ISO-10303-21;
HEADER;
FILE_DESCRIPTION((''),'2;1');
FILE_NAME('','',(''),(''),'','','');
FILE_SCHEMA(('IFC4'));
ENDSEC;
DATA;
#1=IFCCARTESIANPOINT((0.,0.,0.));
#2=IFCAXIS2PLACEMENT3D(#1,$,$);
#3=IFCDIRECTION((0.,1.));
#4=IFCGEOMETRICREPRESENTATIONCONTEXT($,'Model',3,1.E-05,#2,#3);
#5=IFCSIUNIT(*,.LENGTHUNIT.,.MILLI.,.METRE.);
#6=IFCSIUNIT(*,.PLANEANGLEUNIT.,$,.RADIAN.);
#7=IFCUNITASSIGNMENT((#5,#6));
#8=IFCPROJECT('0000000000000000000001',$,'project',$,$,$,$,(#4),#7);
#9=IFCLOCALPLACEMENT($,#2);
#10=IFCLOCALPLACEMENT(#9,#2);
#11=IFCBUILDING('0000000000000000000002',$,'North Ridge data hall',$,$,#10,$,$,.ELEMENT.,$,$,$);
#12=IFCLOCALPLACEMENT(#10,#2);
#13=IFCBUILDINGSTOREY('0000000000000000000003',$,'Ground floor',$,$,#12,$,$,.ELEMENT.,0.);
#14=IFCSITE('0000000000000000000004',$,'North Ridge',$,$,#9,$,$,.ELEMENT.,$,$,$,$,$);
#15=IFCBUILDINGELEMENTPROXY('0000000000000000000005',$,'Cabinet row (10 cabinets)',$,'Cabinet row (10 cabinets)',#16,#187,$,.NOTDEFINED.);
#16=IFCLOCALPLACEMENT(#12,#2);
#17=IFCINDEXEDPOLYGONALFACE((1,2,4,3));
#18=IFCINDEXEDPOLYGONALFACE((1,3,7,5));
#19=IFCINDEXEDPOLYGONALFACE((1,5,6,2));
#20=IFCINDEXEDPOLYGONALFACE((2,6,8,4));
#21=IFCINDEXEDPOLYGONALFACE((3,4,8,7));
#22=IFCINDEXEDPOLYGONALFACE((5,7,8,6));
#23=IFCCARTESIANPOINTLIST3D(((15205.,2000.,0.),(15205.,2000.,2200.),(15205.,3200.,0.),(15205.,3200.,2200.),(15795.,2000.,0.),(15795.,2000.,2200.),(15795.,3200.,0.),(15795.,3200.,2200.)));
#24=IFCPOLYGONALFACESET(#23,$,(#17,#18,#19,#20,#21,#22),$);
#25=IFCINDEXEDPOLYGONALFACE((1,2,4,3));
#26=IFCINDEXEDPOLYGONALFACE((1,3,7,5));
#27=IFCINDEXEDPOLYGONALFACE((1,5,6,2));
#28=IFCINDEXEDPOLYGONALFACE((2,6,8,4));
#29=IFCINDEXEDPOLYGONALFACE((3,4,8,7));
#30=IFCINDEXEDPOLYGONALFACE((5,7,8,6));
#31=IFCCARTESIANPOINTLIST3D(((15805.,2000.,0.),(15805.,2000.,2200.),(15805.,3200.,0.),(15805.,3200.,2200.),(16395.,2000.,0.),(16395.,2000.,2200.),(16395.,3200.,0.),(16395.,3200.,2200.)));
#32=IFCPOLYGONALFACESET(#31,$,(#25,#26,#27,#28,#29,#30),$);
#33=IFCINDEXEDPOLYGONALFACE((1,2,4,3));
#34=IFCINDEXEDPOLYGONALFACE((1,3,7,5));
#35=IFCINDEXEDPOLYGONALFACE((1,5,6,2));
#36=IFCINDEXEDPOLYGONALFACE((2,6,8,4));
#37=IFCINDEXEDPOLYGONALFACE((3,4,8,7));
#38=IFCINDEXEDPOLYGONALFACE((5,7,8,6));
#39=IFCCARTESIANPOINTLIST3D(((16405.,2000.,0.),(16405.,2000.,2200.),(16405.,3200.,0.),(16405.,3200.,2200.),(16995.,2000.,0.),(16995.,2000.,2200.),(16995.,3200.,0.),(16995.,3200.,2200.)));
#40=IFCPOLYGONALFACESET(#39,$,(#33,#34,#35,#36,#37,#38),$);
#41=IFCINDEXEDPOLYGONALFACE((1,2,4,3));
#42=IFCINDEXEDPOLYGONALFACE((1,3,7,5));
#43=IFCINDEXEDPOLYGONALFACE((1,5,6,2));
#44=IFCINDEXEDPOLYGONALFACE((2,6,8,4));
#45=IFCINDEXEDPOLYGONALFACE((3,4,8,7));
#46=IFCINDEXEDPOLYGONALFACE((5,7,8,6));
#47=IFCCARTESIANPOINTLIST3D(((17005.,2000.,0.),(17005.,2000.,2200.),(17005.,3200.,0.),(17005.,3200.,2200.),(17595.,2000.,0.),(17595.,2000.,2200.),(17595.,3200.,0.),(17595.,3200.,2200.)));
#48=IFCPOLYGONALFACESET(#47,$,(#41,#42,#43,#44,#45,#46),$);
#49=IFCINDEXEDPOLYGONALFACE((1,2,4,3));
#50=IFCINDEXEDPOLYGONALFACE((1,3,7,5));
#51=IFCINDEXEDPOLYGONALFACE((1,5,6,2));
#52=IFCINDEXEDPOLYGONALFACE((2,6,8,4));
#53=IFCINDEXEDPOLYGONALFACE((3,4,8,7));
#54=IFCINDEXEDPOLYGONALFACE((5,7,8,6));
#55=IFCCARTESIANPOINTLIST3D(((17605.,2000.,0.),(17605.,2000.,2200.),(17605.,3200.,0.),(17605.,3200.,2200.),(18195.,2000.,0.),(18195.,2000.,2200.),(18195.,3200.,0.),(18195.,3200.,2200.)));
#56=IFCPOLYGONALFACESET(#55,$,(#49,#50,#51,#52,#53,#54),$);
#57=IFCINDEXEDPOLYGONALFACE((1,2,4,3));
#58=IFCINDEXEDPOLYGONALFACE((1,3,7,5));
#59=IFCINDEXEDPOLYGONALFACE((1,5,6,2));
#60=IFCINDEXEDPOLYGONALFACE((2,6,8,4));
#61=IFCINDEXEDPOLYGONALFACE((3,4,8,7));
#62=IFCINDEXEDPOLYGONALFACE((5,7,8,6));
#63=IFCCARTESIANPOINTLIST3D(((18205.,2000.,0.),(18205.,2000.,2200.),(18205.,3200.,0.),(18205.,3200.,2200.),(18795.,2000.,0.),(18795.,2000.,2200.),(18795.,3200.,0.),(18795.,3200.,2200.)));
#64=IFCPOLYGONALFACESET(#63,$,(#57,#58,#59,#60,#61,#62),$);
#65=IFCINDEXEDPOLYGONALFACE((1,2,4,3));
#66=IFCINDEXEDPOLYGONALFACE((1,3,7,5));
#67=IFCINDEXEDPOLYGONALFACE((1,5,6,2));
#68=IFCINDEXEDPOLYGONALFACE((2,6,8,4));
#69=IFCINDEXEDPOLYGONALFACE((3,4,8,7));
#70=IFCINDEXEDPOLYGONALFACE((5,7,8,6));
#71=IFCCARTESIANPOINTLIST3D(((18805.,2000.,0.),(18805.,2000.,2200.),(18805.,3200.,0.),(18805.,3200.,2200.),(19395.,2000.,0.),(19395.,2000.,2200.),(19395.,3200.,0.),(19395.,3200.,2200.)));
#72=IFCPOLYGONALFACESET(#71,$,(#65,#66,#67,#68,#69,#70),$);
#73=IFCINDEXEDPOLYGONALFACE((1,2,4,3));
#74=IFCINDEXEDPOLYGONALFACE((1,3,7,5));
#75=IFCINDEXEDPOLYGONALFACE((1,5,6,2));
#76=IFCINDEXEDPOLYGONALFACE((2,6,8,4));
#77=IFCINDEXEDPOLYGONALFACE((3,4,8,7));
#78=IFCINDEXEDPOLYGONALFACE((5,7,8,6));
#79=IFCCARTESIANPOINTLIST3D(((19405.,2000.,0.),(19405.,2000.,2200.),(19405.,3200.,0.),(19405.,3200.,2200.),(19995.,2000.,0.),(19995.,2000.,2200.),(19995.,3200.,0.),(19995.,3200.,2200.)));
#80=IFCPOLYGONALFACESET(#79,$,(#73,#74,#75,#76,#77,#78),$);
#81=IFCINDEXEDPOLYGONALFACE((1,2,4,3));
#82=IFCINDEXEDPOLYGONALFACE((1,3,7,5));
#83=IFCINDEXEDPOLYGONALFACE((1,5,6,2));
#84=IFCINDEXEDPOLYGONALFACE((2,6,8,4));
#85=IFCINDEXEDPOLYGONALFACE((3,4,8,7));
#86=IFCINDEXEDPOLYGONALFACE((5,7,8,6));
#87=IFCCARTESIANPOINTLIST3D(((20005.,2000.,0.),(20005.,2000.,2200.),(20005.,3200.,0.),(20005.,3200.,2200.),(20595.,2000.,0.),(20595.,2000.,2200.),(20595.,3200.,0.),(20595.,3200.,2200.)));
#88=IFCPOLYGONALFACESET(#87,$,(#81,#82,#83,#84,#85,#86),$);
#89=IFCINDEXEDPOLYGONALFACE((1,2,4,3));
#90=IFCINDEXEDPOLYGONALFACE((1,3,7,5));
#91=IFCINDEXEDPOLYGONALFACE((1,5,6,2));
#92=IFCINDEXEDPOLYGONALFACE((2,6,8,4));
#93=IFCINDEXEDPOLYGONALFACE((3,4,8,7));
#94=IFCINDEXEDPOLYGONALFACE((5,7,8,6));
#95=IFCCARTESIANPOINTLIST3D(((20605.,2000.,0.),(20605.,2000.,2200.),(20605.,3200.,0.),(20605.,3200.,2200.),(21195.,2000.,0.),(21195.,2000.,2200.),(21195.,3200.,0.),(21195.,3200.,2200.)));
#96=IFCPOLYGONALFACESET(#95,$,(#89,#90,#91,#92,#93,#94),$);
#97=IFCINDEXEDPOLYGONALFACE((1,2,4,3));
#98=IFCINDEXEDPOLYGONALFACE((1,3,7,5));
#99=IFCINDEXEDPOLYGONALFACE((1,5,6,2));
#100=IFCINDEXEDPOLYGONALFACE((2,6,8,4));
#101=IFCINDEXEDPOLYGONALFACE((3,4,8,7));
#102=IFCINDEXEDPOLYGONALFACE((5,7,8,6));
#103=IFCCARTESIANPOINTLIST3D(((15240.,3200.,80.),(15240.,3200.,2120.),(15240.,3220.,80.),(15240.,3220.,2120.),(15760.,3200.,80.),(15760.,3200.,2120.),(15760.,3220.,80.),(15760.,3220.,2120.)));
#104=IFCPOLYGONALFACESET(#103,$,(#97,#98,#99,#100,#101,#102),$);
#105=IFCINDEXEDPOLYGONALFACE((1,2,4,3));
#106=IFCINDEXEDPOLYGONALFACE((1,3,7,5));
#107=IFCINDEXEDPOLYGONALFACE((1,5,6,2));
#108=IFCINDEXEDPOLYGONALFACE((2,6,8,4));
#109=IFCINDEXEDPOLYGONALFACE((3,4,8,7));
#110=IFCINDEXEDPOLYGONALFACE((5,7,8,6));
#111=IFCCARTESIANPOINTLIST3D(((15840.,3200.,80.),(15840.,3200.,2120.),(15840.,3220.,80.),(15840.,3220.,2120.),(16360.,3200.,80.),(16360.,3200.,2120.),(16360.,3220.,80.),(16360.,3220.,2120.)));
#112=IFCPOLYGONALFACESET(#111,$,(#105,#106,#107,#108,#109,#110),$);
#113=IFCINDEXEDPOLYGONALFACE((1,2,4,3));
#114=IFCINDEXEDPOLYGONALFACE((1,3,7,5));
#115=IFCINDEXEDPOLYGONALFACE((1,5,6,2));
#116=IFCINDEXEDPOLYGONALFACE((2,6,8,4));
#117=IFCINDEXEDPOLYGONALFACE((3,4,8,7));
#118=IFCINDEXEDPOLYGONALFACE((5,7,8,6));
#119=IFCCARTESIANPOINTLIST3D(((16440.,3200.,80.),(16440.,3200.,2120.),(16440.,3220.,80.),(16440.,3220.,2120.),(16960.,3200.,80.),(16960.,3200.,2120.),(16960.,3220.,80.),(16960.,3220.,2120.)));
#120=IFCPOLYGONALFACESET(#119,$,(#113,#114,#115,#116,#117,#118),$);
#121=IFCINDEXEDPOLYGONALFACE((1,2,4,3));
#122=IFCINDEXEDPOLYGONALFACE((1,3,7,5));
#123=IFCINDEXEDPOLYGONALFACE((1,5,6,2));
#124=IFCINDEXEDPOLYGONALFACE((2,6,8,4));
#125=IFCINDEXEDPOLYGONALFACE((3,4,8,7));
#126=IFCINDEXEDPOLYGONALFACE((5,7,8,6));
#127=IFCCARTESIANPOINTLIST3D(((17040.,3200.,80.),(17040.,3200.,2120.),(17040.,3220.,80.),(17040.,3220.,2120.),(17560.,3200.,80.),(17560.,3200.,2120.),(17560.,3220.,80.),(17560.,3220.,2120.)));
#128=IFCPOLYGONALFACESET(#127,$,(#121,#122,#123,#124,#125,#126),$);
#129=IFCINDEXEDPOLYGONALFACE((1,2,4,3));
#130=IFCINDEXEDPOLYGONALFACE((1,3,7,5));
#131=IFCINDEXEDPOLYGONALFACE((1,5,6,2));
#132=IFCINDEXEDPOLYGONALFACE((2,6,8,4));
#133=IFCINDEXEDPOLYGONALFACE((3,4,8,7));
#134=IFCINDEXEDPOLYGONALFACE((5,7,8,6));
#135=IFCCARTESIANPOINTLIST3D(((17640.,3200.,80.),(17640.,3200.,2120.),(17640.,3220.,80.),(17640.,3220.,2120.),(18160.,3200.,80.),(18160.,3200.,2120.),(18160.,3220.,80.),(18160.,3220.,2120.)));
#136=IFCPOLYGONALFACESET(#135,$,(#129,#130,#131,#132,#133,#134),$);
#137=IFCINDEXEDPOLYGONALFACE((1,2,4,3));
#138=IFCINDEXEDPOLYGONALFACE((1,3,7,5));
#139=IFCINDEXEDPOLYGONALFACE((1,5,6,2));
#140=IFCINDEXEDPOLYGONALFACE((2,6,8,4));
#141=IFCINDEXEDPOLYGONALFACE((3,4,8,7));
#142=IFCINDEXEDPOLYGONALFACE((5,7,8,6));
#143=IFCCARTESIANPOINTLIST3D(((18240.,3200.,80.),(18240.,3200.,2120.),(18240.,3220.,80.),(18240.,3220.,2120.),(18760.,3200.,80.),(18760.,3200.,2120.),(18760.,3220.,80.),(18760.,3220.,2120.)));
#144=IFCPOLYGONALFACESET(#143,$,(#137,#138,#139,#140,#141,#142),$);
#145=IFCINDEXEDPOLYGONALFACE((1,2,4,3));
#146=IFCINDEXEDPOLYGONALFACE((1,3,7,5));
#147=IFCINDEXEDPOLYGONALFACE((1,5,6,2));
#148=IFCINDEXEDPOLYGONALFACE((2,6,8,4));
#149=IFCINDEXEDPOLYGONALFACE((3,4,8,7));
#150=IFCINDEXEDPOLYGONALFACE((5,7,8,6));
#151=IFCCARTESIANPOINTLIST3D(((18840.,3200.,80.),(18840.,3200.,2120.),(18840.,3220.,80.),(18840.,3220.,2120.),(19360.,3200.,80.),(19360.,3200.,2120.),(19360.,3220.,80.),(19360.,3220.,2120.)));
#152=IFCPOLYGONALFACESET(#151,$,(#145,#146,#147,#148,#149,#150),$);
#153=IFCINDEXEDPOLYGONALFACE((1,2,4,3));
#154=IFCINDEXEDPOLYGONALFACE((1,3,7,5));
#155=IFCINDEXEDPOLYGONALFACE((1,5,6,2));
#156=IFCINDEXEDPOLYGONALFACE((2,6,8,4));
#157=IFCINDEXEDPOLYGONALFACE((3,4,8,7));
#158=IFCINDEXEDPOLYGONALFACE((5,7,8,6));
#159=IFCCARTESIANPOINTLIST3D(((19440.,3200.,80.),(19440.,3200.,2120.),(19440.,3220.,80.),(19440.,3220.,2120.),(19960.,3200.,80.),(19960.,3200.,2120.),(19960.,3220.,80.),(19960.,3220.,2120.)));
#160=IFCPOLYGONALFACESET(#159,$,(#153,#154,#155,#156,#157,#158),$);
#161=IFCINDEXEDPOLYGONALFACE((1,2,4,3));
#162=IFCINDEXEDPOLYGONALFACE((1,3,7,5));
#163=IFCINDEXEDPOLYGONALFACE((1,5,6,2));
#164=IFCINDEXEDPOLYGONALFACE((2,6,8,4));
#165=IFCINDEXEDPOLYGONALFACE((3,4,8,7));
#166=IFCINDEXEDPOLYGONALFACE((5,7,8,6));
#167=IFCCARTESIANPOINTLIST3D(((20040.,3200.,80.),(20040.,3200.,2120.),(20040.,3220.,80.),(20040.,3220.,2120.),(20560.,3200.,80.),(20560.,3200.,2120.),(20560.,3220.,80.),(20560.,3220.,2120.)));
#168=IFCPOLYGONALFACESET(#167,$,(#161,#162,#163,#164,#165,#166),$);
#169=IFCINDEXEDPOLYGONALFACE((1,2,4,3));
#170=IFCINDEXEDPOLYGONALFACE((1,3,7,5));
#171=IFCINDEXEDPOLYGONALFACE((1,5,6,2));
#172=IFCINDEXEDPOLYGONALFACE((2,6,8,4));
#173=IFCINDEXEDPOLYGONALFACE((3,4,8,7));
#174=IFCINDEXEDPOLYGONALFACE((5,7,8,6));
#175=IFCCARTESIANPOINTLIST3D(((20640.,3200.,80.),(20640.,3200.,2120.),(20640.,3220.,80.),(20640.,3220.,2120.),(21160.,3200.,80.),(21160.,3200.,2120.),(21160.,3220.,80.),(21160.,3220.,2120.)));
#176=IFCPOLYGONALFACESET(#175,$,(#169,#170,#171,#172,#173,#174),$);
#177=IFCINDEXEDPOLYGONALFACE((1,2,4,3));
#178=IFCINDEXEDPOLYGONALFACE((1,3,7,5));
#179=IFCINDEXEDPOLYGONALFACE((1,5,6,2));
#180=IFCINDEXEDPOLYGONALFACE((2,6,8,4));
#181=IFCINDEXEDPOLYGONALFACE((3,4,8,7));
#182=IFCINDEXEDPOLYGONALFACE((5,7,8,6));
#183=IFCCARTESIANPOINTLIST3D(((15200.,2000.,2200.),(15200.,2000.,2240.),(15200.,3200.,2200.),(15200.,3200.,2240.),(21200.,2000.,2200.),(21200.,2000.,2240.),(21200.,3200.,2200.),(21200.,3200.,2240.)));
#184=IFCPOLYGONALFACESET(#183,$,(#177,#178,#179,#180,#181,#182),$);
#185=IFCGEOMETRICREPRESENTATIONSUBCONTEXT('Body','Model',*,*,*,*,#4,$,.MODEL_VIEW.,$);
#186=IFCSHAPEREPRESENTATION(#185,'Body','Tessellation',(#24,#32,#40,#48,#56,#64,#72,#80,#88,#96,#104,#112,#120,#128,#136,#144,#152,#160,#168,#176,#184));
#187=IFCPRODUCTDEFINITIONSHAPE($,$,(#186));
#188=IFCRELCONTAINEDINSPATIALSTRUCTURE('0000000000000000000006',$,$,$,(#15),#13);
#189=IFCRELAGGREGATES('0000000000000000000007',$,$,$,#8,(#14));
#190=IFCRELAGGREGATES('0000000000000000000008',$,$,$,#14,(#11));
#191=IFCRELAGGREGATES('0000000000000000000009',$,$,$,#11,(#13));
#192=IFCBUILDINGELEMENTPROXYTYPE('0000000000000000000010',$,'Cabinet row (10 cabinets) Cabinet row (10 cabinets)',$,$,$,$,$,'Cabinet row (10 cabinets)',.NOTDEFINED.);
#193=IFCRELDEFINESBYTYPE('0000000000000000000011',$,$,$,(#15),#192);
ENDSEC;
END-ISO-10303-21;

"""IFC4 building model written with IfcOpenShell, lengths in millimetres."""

from ifc_helpers import new_model, si_unit, direction, frame, origin, place, context, subcontext, project, spatial, polyline, outline, extrude, source, transform, mapped, type_object, type_shapes, element, save


model = new_model("IFC4")

# Units and contexts
model_context = context("Model", 3, precision=1e-05, world=origin(), true_north=direction((0.0, 1.0)))
body_context = subcontext(model_context, "Body", "Model", "MODEL_VIEW")
ifc_project = project(units=[si_unit("LENGTHUNIT", "METRE", prefix="MILLI"), si_unit("PLANEANGLEUNIT", "RADIAN")], contexts=[model_context])

# Site, building, storey
site_placement = place(None, origin())
site = spatial("IfcSite", under=ifc_project, at=site_placement, Name="North Ridge", CompositionType="ELEMENT")
building_placement = place(site_placement, origin())
building = spatial("IfcBuilding", under=site, at=building_placement, Name="North Ridge data hall", CompositionType="ELEMENT")
storey_placement = place(building_placement, origin())
storey = spatial("IfcBuildingStorey", under=building, at=storey_placement, Name="Ground floor", CompositionType="ELEMENT", Elevation=0.0)

# Building element proxy
building_element_proxy_type_1 = type_object("IfcBuildingElementProxyType", Name="Cabinet row (10 cabinets) Cabinet row (10 cabinets)", ElementType="Cabinet row (10 cabinets)", PredefinedType="NOTDEFINED")
shared_shape_1 = source(origin(), body_context, "Body", "SweptSolid", [
    extrude(outline(polyline([(5.0, 0.0), (595.0, 0.0), (595.0, 1200.0), (5.0, 1200.0), (5.0, 0.0)])), origin(), (0.0, 0.0, 1.0), 2200.0),
    extrude(outline(polyline([(605.0, 0.0), (1195.0, 0.0), (1195.0, 1200.0), (605.0, 1200.0), (605.0, 0.0)])), origin(), (0.0, 0.0, 1.0), 2200.0),
    extrude(outline(polyline([(1205.0, 0.0), (1795.0, 0.0), (1795.0, 1200.0), (1205.0, 1200.0), (1205.0, 0.0)])), origin(), (0.0, 0.0, 1.0), 2200.0),
    extrude(outline(polyline([(1805.0, 0.0), (2395.0, 0.0), (2395.0, 1200.0), (1805.0, 1200.0), (1805.0, 0.0)])), origin(), (0.0, 0.0, 1.0), 2200.0),
    extrude(outline(polyline([(2405.0, 0.0), (2995.0, 0.0), (2995.0, 1200.0), (2405.0, 1200.0), (2405.0, 0.0)])), origin(), (0.0, 0.0, 1.0), 2200.0),
    extrude(outline(polyline([(3005.0, 0.0), (3595.0, 0.0), (3595.0, 1200.0), (3005.0, 1200.0), (3005.0, 0.0)])), origin(), (0.0, 0.0, 1.0), 2200.0),
    extrude(outline(polyline([(3605.0, 0.0), (4195.0, 0.0), (4195.0, 1200.0), (3605.0, 1200.0), (3605.0, 0.0)])), origin(), (0.0, 0.0, 1.0), 2200.0),
    extrude(outline(polyline([(4205.0, 0.0), (4795.0, 0.0), (4795.0, 1200.0), (4205.0, 1200.0), (4205.0, 0.0)])), origin(), (0.0, 0.0, 1.0), 2200.0),
    extrude(outline(polyline([(4805.0, 0.0), (5395.0, 0.0), (5395.0, 1200.0), (4805.0, 1200.0), (4805.0, 0.0)])), origin(), (0.0, 0.0, 1.0), 2200.0),
    extrude(outline(polyline([(5405.0, 0.0), (5995.0, 0.0), (5995.0, 1200.0), (5405.0, 1200.0), (5405.0, 0.0)])), origin(), (0.0, 0.0, 1.0), 2200.0),
    extrude(outline(polyline([(40.0, 1200.0), (560.0, 1200.0), (560.0, 1220.0), (40.0, 1220.0), (40.0, 1200.0)])), frame((0.0, 0.0, 80.0)), (0.0, 0.0, 1.0), 2040.0),
    extrude(outline(polyline([(640.0, 1200.0), (1160.0, 1200.0), (1160.0, 1220.0), (640.0, 1220.0), (640.0, 1200.0)])), frame((0.0, 0.0, 80.0)), (0.0, 0.0, 1.0), 2040.0),
    extrude(outline(polyline([(1240.0, 1200.0), (1760.0, 1200.0), (1760.0, 1220.0), (1240.0, 1220.0), (1240.0, 1200.0)])), frame((0.0, 0.0, 80.0)), (0.0, 0.0, 1.0), 2040.0),
    extrude(outline(polyline([(1840.0, 1200.0), (2360.0, 1200.0), (2360.0, 1220.0), (1840.0, 1220.0), (1840.0, 1200.0)])), frame((0.0, 0.0, 80.0)), (0.0, 0.0, 1.0), 2040.0),
    extrude(outline(polyline([(2440.0, 1200.0), (2960.0, 1200.0), (2960.0, 1220.0), (2440.0, 1220.0), (2440.0, 1200.0)])), frame((0.0, 0.0, 80.0)), (0.0, 0.0, 1.0), 2040.0),
    extrude(outline(polyline([(3040.0, 1200.0), (3560.0, 1200.0), (3560.0, 1220.0), (3040.0, 1220.0), (3040.0, 1200.0)])), frame((0.0, 0.0, 80.0)), (0.0, 0.0, 1.0), 2040.0),
    extrude(outline(polyline([(3640.0, 1200.0), (4160.0, 1200.0), (4160.0, 1220.0), (3640.0, 1220.0), (3640.0, 1200.0)])), frame((0.0, 0.0, 80.0)), (0.0, 0.0, 1.0), 2040.0),
    extrude(outline(polyline([(4240.0, 1200.0), (4760.0, 1200.0), (4760.0, 1220.0), (4240.0, 1220.0), (4240.0, 1200.0)])), frame((0.0, 0.0, 80.0)), (0.0, 0.0, 1.0), 2040.0),
    extrude(outline(polyline([(4840.0, 1200.0), (5360.0, 1200.0), (5360.0, 1220.0), (4840.0, 1220.0), (4840.0, 1200.0)])), frame((0.0, 0.0, 80.0)), (0.0, 0.0, 1.0), 2040.0),
    extrude(outline(polyline([(5440.0, 1200.0), (5960.0, 1200.0), (5960.0, 1220.0), (5440.0, 1220.0), (5440.0, 1200.0)])), frame((0.0, 0.0, 80.0)), (0.0, 0.0, 1.0), 2040.0),
    extrude(outline(polyline([(0.0, 0.0), (6000.0, 0.0), (6000.0, 1200.0), (0.0, 1200.0), (0.0, 0.0)])), frame((0.0, 0.0, 2200.0)), (0.0, 0.0, 1.0), 40.0),
])
type_shapes(building_element_proxy_type_1, [shared_shape_1])
for number, where, z_axis, x_axis, name in (
    (1, (15200.0, 2000.0, 0.0), (0.0, 0.0, 1.0), (1.0, 0.0, 0.0), "Cabinet row (10 cabinets)"),
):
    element("IfcBuildingElementProxy", number, at=place(storey_placement, frame(where, z_axis=z_axis, x_axis=x_axis)), inside=storey, type_object=building_element_proxy_type_1, Name=name, ObjectType="Cabinet row (10 cabinets)", PredefinedType="NOTDEFINED", context=body_context, shape_type="MappedRepresentation", body=[
        mapped(shared_shape_1, transform((0.0, 0.0, 0.0))),
    ])

save(model, "model.ifc")
